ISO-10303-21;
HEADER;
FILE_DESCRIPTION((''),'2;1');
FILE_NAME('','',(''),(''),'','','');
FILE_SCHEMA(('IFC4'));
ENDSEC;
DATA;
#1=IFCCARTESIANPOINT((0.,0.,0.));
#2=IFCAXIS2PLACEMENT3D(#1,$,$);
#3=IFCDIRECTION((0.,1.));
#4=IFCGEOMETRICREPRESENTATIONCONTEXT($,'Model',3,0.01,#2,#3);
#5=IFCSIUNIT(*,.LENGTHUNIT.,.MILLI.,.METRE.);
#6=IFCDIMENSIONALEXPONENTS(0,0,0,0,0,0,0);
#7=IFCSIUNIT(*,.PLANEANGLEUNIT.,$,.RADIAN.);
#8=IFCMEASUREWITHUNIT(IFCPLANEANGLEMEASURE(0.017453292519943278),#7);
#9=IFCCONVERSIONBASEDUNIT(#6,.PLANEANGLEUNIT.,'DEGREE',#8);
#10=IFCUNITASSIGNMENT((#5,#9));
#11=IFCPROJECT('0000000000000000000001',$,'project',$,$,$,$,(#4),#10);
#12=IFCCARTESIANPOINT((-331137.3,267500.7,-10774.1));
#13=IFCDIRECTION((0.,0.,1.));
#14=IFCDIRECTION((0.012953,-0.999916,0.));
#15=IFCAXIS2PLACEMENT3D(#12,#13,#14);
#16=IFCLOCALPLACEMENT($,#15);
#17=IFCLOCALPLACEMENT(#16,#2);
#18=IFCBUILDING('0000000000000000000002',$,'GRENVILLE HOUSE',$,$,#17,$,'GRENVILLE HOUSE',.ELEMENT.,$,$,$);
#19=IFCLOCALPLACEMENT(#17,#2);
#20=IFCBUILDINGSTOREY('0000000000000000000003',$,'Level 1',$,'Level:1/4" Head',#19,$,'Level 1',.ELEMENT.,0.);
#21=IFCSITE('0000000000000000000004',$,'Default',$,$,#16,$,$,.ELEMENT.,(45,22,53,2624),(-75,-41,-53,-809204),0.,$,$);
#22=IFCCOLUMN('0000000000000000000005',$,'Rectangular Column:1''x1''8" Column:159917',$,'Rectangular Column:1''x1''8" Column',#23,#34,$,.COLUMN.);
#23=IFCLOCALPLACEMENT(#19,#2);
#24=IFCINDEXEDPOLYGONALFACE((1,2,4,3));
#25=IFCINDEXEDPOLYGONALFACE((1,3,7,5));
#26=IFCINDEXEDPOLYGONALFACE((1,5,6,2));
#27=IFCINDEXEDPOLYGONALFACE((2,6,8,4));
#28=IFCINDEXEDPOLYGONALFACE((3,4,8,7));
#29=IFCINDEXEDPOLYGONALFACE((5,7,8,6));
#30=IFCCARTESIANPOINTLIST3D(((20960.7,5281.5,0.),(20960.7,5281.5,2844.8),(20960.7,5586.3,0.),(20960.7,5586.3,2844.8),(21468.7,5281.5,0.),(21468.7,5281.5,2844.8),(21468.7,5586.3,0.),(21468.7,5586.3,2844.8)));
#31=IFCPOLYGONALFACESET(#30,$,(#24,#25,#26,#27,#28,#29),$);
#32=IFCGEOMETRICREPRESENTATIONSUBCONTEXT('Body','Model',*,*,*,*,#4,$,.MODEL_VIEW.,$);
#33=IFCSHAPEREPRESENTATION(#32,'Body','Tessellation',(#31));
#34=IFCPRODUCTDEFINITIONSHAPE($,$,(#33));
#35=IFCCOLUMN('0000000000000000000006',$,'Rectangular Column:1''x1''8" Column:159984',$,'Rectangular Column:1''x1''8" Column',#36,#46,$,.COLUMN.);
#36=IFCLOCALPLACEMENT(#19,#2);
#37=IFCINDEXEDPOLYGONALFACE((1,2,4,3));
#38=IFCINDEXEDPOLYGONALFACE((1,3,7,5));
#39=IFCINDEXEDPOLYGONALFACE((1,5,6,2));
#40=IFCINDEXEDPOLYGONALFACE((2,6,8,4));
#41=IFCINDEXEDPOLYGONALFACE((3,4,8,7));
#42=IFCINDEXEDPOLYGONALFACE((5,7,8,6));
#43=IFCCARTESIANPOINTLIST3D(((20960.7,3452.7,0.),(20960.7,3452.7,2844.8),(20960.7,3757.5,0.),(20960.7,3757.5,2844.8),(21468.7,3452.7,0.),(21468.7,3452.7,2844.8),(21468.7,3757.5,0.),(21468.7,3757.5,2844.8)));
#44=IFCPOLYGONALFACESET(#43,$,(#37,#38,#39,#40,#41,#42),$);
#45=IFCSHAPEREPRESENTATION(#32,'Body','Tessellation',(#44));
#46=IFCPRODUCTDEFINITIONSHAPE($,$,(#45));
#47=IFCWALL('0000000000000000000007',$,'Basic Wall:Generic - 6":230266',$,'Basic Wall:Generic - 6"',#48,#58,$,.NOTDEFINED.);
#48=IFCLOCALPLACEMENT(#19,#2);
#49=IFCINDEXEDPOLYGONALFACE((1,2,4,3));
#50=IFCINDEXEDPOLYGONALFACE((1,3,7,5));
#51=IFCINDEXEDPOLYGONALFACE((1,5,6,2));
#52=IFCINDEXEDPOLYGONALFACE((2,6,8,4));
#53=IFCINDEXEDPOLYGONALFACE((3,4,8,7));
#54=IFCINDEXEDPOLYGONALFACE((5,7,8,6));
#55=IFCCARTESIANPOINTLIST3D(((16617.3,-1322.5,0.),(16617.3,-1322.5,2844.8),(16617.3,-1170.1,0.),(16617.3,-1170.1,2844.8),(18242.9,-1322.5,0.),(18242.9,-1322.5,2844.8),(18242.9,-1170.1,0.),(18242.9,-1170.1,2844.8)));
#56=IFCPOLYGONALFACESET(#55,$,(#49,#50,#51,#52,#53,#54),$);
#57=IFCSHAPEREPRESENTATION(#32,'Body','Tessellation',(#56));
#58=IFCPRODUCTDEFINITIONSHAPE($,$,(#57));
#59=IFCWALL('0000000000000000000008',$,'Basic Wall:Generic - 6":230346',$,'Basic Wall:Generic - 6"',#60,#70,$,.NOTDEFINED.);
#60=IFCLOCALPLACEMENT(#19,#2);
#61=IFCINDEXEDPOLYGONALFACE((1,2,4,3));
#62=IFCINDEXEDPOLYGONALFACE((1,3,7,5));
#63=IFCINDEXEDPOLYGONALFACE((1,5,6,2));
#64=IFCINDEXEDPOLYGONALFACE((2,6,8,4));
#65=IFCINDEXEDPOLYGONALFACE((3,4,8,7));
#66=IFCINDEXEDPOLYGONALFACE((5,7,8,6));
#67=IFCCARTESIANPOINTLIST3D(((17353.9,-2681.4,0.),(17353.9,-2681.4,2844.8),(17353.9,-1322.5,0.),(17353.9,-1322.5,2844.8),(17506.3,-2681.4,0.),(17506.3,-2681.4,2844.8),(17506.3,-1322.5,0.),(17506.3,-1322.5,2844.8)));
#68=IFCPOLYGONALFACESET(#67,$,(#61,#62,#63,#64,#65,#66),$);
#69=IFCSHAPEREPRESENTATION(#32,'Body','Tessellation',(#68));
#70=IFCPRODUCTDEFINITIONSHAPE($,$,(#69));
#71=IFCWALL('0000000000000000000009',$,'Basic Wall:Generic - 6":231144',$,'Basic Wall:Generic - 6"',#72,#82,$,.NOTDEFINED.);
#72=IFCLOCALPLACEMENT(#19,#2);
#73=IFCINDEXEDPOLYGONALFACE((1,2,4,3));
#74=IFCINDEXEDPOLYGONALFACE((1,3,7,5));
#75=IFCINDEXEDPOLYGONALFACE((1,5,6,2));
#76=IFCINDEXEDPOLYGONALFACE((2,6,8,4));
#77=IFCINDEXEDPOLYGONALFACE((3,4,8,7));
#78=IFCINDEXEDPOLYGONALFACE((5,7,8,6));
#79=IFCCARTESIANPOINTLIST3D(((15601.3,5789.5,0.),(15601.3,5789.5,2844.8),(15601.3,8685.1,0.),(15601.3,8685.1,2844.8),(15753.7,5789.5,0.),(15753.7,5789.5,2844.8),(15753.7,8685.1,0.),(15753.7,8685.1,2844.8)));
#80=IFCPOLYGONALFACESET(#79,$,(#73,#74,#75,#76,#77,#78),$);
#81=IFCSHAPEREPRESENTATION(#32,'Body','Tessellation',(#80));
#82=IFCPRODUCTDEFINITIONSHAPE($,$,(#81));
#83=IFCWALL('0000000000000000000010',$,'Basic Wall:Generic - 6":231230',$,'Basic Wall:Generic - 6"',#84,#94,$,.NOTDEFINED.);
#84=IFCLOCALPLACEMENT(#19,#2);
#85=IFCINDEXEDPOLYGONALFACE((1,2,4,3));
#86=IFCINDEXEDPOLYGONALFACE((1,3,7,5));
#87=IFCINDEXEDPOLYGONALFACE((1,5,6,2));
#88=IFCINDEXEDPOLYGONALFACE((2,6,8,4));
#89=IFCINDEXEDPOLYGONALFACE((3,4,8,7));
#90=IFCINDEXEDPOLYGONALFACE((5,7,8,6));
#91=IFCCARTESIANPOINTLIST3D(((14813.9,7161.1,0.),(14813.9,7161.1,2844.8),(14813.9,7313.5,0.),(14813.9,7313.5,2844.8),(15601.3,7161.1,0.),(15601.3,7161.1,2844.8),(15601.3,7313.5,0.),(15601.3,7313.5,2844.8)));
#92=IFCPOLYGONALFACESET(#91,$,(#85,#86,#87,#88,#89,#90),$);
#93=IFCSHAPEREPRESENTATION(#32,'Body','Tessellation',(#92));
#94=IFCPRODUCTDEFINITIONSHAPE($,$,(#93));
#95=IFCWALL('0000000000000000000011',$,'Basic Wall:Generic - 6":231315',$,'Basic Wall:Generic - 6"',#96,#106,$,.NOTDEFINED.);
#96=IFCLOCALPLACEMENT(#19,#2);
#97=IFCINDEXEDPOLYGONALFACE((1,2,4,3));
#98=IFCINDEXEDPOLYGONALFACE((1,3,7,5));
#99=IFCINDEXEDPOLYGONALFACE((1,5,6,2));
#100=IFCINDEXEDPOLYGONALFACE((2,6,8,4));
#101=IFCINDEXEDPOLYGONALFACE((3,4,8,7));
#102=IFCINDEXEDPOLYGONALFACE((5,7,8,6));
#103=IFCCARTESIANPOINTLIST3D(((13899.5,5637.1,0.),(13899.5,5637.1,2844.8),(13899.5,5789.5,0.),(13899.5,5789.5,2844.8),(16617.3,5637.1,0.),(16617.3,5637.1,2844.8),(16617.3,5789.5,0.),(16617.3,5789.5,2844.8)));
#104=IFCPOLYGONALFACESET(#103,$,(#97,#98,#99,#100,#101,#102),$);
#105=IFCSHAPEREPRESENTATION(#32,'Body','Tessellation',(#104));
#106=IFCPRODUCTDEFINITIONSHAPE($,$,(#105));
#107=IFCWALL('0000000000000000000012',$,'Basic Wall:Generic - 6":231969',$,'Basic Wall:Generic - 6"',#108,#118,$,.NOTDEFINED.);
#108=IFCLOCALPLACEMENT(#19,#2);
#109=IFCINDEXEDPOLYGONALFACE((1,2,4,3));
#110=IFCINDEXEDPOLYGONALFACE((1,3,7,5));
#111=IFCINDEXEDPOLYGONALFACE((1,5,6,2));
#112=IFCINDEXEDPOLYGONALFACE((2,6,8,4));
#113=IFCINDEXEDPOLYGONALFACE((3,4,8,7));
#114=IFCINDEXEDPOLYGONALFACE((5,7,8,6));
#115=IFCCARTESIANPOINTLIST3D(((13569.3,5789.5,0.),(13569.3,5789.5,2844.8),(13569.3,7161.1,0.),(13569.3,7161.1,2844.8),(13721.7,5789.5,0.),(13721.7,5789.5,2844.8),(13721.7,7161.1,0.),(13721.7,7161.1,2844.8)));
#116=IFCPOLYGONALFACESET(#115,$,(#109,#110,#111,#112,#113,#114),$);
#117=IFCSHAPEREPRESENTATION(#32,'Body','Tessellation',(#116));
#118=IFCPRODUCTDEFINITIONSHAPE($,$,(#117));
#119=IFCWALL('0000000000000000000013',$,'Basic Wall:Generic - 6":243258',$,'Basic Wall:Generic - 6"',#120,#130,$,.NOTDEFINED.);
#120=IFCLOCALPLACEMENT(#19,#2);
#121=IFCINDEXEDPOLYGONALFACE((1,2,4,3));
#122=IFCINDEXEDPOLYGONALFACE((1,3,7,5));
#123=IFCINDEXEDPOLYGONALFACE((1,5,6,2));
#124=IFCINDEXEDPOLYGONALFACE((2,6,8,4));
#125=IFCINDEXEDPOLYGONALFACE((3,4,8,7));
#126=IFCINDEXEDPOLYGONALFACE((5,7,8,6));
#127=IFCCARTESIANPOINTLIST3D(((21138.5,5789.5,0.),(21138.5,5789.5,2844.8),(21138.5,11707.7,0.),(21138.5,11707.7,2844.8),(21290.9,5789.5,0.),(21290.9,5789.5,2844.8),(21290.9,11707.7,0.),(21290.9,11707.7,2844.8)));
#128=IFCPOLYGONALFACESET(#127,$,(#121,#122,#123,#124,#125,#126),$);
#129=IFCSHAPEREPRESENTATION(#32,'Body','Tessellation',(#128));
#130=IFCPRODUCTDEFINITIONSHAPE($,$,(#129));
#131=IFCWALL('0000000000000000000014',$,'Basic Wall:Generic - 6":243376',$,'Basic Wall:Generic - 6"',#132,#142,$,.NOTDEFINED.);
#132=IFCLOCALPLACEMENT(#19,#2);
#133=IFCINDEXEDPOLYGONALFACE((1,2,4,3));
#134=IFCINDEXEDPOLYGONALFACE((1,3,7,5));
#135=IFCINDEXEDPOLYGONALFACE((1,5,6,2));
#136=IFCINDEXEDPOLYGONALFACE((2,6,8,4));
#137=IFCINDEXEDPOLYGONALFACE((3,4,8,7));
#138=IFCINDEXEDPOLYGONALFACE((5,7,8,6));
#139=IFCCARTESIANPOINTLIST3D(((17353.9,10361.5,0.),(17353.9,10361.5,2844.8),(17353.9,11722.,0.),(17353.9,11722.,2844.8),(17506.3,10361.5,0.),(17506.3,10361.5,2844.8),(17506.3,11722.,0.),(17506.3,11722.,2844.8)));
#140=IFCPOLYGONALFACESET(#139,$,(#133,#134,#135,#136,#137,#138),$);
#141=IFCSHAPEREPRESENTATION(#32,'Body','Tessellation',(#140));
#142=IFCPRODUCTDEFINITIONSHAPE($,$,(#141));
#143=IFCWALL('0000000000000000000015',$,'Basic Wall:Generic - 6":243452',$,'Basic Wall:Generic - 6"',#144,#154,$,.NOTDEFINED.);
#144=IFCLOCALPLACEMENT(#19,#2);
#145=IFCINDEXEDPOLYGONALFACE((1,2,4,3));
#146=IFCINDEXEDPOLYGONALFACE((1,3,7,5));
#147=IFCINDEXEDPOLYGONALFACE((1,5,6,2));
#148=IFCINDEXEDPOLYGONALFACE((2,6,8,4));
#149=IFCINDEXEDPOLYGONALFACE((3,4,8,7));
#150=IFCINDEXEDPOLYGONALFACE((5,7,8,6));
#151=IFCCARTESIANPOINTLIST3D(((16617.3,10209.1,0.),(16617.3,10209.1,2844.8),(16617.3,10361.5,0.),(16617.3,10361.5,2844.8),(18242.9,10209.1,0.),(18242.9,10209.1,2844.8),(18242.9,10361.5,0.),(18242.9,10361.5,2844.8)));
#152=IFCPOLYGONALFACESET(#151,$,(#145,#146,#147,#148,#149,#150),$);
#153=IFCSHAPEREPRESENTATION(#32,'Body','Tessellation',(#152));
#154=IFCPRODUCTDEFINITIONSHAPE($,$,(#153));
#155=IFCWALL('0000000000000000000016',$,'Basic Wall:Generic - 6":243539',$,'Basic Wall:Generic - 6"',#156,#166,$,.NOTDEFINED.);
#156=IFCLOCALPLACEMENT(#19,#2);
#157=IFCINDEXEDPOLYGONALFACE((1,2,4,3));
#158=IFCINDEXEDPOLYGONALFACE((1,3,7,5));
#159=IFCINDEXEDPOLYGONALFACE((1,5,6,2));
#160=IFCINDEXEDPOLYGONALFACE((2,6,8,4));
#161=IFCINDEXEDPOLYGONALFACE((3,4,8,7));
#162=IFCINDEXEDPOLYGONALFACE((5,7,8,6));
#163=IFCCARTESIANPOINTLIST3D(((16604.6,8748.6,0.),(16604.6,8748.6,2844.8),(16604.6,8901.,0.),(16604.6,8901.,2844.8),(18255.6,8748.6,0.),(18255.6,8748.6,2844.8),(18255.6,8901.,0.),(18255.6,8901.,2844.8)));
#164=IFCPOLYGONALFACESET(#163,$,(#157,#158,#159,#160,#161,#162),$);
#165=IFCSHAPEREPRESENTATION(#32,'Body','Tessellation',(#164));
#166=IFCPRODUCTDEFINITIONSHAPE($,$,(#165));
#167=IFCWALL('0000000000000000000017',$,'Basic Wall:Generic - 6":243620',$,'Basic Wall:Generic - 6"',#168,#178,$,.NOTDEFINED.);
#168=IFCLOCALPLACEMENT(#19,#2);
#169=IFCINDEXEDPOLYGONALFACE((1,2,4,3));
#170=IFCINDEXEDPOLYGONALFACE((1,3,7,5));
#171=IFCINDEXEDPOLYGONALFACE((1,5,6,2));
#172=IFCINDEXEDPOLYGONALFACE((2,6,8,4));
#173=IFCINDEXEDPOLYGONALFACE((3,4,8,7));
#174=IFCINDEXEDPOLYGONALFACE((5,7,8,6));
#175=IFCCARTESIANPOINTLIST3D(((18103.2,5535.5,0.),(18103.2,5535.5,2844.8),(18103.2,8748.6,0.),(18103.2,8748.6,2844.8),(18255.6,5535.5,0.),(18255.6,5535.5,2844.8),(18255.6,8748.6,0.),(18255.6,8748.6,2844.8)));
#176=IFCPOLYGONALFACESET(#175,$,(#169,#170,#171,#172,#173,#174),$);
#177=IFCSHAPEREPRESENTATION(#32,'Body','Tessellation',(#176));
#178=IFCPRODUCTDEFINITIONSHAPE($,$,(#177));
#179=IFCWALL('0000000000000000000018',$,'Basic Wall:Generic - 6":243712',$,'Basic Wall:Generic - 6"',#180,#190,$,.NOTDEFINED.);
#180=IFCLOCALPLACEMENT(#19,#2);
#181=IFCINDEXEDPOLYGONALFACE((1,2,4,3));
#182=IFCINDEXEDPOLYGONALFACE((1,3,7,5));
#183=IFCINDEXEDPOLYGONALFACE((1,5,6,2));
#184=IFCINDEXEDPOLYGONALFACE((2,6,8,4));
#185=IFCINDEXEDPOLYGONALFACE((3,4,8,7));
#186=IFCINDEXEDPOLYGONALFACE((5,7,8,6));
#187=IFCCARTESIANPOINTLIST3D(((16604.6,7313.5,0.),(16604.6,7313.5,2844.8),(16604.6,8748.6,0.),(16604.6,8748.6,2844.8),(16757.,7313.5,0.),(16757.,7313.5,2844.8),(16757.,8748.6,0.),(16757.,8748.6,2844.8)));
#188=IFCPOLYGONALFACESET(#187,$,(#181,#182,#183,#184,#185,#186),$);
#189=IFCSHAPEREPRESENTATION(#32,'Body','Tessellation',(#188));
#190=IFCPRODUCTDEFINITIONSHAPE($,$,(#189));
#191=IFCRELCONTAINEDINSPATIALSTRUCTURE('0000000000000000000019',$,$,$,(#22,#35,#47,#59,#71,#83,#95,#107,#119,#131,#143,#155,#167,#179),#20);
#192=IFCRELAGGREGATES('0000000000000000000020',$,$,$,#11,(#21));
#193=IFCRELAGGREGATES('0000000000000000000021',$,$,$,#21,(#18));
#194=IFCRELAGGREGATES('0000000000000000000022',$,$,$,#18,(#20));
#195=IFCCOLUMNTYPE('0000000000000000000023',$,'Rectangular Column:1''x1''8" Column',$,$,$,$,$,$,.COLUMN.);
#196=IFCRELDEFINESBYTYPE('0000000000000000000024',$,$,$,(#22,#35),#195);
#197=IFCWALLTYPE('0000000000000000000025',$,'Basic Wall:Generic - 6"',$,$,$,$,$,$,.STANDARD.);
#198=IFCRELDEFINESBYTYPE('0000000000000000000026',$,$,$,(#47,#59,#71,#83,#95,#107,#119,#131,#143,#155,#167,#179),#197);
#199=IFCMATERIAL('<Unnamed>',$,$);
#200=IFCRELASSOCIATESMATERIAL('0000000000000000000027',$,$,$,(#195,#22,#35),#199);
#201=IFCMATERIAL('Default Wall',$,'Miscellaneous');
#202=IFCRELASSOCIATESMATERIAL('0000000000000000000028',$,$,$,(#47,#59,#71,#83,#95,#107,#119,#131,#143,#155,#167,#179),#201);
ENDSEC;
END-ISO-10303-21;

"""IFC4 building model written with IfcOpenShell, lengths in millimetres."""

from ifc_helpers import new_model, entity, si_unit, converted_unit, direction, frame, origin, place, context, subcontext, project, spatial, indexed_curve, outline, extrude, source, transform, mapped, material, type_object, type_shapes, element, save


model = new_model("IFC4")

# Units and contexts
model_context = context("Model", 3, precision=0.01, world=origin(), true_north=direction((0.0, 1.0)))
body_context = subcontext(model_context, "Body", "Model", "MODEL_VIEW")
ifc_project = project(units=[si_unit("LENGTHUNIT", "METRE", prefix="MILLI"), converted_unit("PLANEANGLEUNIT", "DEGREE", entity("IfcPlaneAngleMeasure", 0.017453292519943278), si_unit("PLANEANGLEUNIT", "RADIAN"), dimensions=[0, 0, 0, 0, 0, 0, 0])], contexts=[model_context])

# Site, building, storey
site_placement = place(None, frame((-331137.3, 267500.7, -10774.1), z_axis=(0.0, 0.0, 1.0), x_axis=(0.012953, -0.999916, 0.0)))
site = spatial("IfcSite", under=ifc_project, at=site_placement, Name="Default", CompositionType="ELEMENT", RefLatitude=(45, 22, 53, 2624), RefLongitude=(-75, -41, -53, -809204), RefElevation=0.0)
building_placement = place(site_placement, origin())
building = spatial("IfcBuilding", under=site, at=building_placement, Name="GRENVILLE HOUSE", LongName="GRENVILLE HOUSE", CompositionType="ELEMENT")
storey_placement = place(building_placement, origin())
storey = spatial("IfcBuildingStorey", under=building, at=storey_placement, Name="Level 1", ObjectType="Level:1/4\" Head", LongName="Level 1", CompositionType="ELEMENT", Elevation=0.0)

# Columns
ifc_material_1 = material(Name="<Unnamed>")
column_type = type_object("IfcColumnType", Name="Rectangular Column:1'x1'8\" Column", PredefinedType="COLUMN", material=ifc_material_1)
shared_shape = source(origin(), body_context, "Body", "SweptSolid", [
    extrude(outline(indexed_curve([(-254.0, -152.4), (254.0, -152.4), (254.0, 152.4), (-254.0, 152.4), (-254.0, -152.4)], self_intersect=False)), frame((0.0, 0.0, 0.0), z_axis=(0.0, 0.0, 1.0), x_axis=(-1.0, 0.0, 0.0)), (0.0, 0.0, 1.0), 2844.8),
])
type_shapes(column_type, [shared_shape])
for number, where, name in (
    (1, (21214.7, 5433.9, 0.0), "Rectangular Column:1'x1'8\" Column:159917"),
    (2, (21214.7, 3605.1, 0.0), "Rectangular Column:1'x1'8\" Column:159984"),
):
    element("IfcColumn", number, at=place(storey_placement, frame(where)), inside=storey, type_object=column_type, material=ifc_material_1, Name=name, ObjectType="Rectangular Column:1'x1'8\" Column", PredefinedType="COLUMN", context=body_context, shape_type="MappedRepresentation", body=[
        mapped(shared_shape, transform((0.0, 0.0, 0.0), scale=1.0)),
    ])

# Walls
ifc_material_2 = material(Name="Default Wall", Category="Miscellaneous")
wall_type_1 = type_object("IfcWallType", Name="Basic Wall:Generic - 6\"", PredefinedType="STANDARD")
wall_1_placement = place(storey_placement, frame((16617.3, -1246.3, 0.0)))
element("IfcWall", 3, at=wall_1_placement, inside=storey, type_object=wall_type_1, material=ifc_material_2, Name="Basic Wall:Generic - 6\":230266", ObjectType="Basic Wall:Generic - 6\"", PredefinedType="NOTDEFINED", context=body_context, shape_type="SweptSolid", body=[
    extrude(outline(indexed_curve([(1625.6, 76.2), (0.0, 76.2), (0.0, -76.2), (1625.6, -76.2), (1625.6, 76.2)], self_intersect=False)), origin(), (0.0, 0.0, 1.0), 2844.8),
])
wall_2_placement = place(storey_placement, frame((17430.1, -1322.5, 0.0), z_axis=(0.0, 0.0, 1.0), x_axis=(0.0, -1.0, 0.0)))
element("IfcWall", 4, at=wall_2_placement, inside=storey, type_object=wall_type_1, material=ifc_material_2, Name="Basic Wall:Generic - 6\":230346", ObjectType="Basic Wall:Generic - 6\"", PredefinedType="NOTDEFINED", context=body_context, shape_type="SweptSolid", body=[
    extrude(outline(indexed_curve([(1358.9, 76.2), (0.0, 76.2), (0.0, -76.2), (1358.9, -76.2), (1358.9, 76.2)], self_intersect=False)), origin(), (0.0, 0.0, 1.0), 2844.8),
])
wall_3_placement = place(storey_placement, frame((15677.5, 8685.1, 0.0), z_axis=(0.0, 0.0, 1.0), x_axis=(0.0, -1.0, 0.0)))
element("IfcWall", 5, at=wall_3_placement, inside=storey, type_object=wall_type_1, material=ifc_material_2, Name="Basic Wall:Generic - 6\":231144", ObjectType="Basic Wall:Generic - 6\"", PredefinedType="NOTDEFINED", context=body_context, shape_type="SweptSolid", body=[
    extrude(outline(indexed_curve([(2895.6, 76.2), (0.0, 76.2), (0.0, -76.2), (2895.6, -76.2), (2895.6, 76.2)], self_intersect=False)), origin(), (0.0, 0.0, 1.0), 2844.8),
])
wall_4_placement = place(storey_placement, frame((14813.9, 7237.3, 0.0)))
element("IfcWall", 6, at=wall_4_placement, inside=storey, type_object=wall_type_1, material=ifc_material_2, Name="Basic Wall:Generic - 6\":231230", ObjectType="Basic Wall:Generic - 6\"", PredefinedType="NOTDEFINED", context=body_context, shape_type="SweptSolid", body=[
    extrude(outline(indexed_curve([(787.4, 76.2), (0.0, 76.2), (0.0, -76.2), (787.4, -76.2), (787.4, 76.2)], self_intersect=False)), origin(), (0.0, 0.0, 1.0), 2844.8),
])
wall_5_placement = place(storey_placement, frame((13899.5, 5713.3, 0.0)))
element("IfcWall", 7, at=wall_5_placement, inside=storey, type_object=wall_type_1, material=ifc_material_2, Name="Basic Wall:Generic - 6\":231315", ObjectType="Basic Wall:Generic - 6\"", PredefinedType="NOTDEFINED", context=body_context, shape_type="SweptSolid", body=[
    extrude(outline(indexed_curve([(2717.8, 76.2), (0.0, 76.2), (0.0, -76.2), (2717.8, -76.2), (2717.8, 76.2)], self_intersect=False)), origin(), (0.0, 0.0, 1.0), 2844.8),
])
wall_6_placement = place(storey_placement, frame((13645.5, 7161.1, 0.0), z_axis=(0.0, 0.0, 1.0), x_axis=(0.0, -1.0, 0.0)))
element("IfcWall", 8, at=wall_6_placement, inside=storey, type_object=wall_type_1, material=ifc_material_2, Name="Basic Wall:Generic - 6\":231969", ObjectType="Basic Wall:Generic - 6\"", PredefinedType="NOTDEFINED", context=body_context, shape_type="SweptSolid", body=[
    extrude(outline(indexed_curve([(1371.6, 76.2), (0.0, 76.2), (0.0, -76.2), (1371.6, -76.2), (1371.6, 76.2)], self_intersect=False)), origin(), (0.0, 0.0, 1.0), 2844.8),
])
wall_7_placement = place(storey_placement, frame((21214.7, 5789.5, 0.0), z_axis=(0.0, 0.0, 1.0), x_axis=(0.0, 1.0, 0.0)))
element("IfcWall", 9, at=wall_7_placement, inside=storey, type_object=wall_type_1, material=ifc_material_2, Name="Basic Wall:Generic - 6\":243258", ObjectType="Basic Wall:Generic - 6\"", PredefinedType="NOTDEFINED", context=body_context, shape_type="SweptSolid", body=[
    extrude(outline(indexed_curve([(5918.2, 76.2), (0.0, 76.2), (0.0, -76.2), (5918.2, -76.2), (5918.2, 76.2)], self_intersect=False)), origin(), (0.0, 0.0, 1.0), 2844.8),
])
wall_8_placement = place(storey_placement, frame((17430.1, 11722.0, 0.0), z_axis=(0.0, 0.0, 1.0), x_axis=(0.0, -1.0, 0.0)))
element("IfcWall", 10, at=wall_8_placement, inside=storey, type_object=wall_type_1, material=ifc_material_2, Name="Basic Wall:Generic - 6\":243376", ObjectType="Basic Wall:Generic - 6\"", PredefinedType="NOTDEFINED", context=body_context, shape_type="SweptSolid", body=[
    extrude(outline(indexed_curve([(1360.5, 76.2), (0.0, 76.2), (0.0, -76.2), (1360.5, -76.2), (1360.5, 76.2)], self_intersect=False)), origin(), (0.0, 0.0, 1.0), 2844.8),
])
wall_9_placement = place(storey_placement, frame((16617.3, 10285.3, 0.0)))
element("IfcWall", 11, at=wall_9_placement, inside=storey, type_object=wall_type_1, material=ifc_material_2, Name="Basic Wall:Generic - 6\":243452", ObjectType="Basic Wall:Generic - 6\"", PredefinedType="NOTDEFINED", context=body_context, shape_type="SweptSolid", body=[
    extrude(outline(indexed_curve([(1625.6, 76.2), (0.0, 76.2), (0.0, -76.2), (1625.6, -76.2), (1625.6, 76.2)], self_intersect=False)), origin(), (0.0, 0.0, 1.0), 2844.8),
])
wall_10_placement = place(storey_placement, frame((16604.6, 8824.8, 0.0)))
element("IfcWall", 12, at=wall_10_placement, inside=storey, type_object=wall_type_1, material=ifc_material_2, Name="Basic Wall:Generic - 6\":243539", ObjectType="Basic Wall:Generic - 6\"", PredefinedType="NOTDEFINED", context=body_context, shape_type="SweptSolid", body=[
    extrude(outline(indexed_curve([(1651.0, 76.2), (0.0, 76.2), (0.0, -76.2), (1651.0, -76.2), (1651.0, 76.2)], self_intersect=False)), origin(), (0.0, 0.0, 1.0), 2844.8),
])
wall_11_placement = place(storey_placement, frame((18179.4, 8748.6, 0.0), z_axis=(0.0, 0.0, 1.0), x_axis=(0.0, -1.0, 0.0)))
element("IfcWall", 13, at=wall_11_placement, inside=storey, type_object=wall_type_1, material=ifc_material_2, Name="Basic Wall:Generic - 6\":243620", ObjectType="Basic Wall:Generic - 6\"", PredefinedType="NOTDEFINED", context=body_context, shape_type="SweptSolid", body=[
    extrude(outline(indexed_curve([(3213.1, 76.2), (0.0, 76.2), (0.0, -76.2), (3213.1, -76.2), (3213.1, 76.2)], self_intersect=False)), origin(), (0.0, 0.0, 1.0), 2844.8),
])
wall_12_placement = place(storey_placement, frame((16680.8, 8748.6, 0.0), z_axis=(0.0, 0.0, 1.0), x_axis=(0.0, -1.0, 0.0)))
element("IfcWall", 14, at=wall_12_placement, inside=storey, type_object=wall_type_1, material=ifc_material_2, Name="Basic Wall:Generic - 6\":243712", ObjectType="Basic Wall:Generic - 6\"", PredefinedType="NOTDEFINED", context=body_context, shape_type="SweptSolid", body=[
    extrude(outline(indexed_curve([(1435.1, 76.2), (0.0, 76.2), (0.0, -76.2), (1435.1, -76.2), (1435.1, 76.2)], self_intersect=False)), origin(), (0.0, 0.0, 1.0), 2844.8),
])

save(model, "model.ifc")
